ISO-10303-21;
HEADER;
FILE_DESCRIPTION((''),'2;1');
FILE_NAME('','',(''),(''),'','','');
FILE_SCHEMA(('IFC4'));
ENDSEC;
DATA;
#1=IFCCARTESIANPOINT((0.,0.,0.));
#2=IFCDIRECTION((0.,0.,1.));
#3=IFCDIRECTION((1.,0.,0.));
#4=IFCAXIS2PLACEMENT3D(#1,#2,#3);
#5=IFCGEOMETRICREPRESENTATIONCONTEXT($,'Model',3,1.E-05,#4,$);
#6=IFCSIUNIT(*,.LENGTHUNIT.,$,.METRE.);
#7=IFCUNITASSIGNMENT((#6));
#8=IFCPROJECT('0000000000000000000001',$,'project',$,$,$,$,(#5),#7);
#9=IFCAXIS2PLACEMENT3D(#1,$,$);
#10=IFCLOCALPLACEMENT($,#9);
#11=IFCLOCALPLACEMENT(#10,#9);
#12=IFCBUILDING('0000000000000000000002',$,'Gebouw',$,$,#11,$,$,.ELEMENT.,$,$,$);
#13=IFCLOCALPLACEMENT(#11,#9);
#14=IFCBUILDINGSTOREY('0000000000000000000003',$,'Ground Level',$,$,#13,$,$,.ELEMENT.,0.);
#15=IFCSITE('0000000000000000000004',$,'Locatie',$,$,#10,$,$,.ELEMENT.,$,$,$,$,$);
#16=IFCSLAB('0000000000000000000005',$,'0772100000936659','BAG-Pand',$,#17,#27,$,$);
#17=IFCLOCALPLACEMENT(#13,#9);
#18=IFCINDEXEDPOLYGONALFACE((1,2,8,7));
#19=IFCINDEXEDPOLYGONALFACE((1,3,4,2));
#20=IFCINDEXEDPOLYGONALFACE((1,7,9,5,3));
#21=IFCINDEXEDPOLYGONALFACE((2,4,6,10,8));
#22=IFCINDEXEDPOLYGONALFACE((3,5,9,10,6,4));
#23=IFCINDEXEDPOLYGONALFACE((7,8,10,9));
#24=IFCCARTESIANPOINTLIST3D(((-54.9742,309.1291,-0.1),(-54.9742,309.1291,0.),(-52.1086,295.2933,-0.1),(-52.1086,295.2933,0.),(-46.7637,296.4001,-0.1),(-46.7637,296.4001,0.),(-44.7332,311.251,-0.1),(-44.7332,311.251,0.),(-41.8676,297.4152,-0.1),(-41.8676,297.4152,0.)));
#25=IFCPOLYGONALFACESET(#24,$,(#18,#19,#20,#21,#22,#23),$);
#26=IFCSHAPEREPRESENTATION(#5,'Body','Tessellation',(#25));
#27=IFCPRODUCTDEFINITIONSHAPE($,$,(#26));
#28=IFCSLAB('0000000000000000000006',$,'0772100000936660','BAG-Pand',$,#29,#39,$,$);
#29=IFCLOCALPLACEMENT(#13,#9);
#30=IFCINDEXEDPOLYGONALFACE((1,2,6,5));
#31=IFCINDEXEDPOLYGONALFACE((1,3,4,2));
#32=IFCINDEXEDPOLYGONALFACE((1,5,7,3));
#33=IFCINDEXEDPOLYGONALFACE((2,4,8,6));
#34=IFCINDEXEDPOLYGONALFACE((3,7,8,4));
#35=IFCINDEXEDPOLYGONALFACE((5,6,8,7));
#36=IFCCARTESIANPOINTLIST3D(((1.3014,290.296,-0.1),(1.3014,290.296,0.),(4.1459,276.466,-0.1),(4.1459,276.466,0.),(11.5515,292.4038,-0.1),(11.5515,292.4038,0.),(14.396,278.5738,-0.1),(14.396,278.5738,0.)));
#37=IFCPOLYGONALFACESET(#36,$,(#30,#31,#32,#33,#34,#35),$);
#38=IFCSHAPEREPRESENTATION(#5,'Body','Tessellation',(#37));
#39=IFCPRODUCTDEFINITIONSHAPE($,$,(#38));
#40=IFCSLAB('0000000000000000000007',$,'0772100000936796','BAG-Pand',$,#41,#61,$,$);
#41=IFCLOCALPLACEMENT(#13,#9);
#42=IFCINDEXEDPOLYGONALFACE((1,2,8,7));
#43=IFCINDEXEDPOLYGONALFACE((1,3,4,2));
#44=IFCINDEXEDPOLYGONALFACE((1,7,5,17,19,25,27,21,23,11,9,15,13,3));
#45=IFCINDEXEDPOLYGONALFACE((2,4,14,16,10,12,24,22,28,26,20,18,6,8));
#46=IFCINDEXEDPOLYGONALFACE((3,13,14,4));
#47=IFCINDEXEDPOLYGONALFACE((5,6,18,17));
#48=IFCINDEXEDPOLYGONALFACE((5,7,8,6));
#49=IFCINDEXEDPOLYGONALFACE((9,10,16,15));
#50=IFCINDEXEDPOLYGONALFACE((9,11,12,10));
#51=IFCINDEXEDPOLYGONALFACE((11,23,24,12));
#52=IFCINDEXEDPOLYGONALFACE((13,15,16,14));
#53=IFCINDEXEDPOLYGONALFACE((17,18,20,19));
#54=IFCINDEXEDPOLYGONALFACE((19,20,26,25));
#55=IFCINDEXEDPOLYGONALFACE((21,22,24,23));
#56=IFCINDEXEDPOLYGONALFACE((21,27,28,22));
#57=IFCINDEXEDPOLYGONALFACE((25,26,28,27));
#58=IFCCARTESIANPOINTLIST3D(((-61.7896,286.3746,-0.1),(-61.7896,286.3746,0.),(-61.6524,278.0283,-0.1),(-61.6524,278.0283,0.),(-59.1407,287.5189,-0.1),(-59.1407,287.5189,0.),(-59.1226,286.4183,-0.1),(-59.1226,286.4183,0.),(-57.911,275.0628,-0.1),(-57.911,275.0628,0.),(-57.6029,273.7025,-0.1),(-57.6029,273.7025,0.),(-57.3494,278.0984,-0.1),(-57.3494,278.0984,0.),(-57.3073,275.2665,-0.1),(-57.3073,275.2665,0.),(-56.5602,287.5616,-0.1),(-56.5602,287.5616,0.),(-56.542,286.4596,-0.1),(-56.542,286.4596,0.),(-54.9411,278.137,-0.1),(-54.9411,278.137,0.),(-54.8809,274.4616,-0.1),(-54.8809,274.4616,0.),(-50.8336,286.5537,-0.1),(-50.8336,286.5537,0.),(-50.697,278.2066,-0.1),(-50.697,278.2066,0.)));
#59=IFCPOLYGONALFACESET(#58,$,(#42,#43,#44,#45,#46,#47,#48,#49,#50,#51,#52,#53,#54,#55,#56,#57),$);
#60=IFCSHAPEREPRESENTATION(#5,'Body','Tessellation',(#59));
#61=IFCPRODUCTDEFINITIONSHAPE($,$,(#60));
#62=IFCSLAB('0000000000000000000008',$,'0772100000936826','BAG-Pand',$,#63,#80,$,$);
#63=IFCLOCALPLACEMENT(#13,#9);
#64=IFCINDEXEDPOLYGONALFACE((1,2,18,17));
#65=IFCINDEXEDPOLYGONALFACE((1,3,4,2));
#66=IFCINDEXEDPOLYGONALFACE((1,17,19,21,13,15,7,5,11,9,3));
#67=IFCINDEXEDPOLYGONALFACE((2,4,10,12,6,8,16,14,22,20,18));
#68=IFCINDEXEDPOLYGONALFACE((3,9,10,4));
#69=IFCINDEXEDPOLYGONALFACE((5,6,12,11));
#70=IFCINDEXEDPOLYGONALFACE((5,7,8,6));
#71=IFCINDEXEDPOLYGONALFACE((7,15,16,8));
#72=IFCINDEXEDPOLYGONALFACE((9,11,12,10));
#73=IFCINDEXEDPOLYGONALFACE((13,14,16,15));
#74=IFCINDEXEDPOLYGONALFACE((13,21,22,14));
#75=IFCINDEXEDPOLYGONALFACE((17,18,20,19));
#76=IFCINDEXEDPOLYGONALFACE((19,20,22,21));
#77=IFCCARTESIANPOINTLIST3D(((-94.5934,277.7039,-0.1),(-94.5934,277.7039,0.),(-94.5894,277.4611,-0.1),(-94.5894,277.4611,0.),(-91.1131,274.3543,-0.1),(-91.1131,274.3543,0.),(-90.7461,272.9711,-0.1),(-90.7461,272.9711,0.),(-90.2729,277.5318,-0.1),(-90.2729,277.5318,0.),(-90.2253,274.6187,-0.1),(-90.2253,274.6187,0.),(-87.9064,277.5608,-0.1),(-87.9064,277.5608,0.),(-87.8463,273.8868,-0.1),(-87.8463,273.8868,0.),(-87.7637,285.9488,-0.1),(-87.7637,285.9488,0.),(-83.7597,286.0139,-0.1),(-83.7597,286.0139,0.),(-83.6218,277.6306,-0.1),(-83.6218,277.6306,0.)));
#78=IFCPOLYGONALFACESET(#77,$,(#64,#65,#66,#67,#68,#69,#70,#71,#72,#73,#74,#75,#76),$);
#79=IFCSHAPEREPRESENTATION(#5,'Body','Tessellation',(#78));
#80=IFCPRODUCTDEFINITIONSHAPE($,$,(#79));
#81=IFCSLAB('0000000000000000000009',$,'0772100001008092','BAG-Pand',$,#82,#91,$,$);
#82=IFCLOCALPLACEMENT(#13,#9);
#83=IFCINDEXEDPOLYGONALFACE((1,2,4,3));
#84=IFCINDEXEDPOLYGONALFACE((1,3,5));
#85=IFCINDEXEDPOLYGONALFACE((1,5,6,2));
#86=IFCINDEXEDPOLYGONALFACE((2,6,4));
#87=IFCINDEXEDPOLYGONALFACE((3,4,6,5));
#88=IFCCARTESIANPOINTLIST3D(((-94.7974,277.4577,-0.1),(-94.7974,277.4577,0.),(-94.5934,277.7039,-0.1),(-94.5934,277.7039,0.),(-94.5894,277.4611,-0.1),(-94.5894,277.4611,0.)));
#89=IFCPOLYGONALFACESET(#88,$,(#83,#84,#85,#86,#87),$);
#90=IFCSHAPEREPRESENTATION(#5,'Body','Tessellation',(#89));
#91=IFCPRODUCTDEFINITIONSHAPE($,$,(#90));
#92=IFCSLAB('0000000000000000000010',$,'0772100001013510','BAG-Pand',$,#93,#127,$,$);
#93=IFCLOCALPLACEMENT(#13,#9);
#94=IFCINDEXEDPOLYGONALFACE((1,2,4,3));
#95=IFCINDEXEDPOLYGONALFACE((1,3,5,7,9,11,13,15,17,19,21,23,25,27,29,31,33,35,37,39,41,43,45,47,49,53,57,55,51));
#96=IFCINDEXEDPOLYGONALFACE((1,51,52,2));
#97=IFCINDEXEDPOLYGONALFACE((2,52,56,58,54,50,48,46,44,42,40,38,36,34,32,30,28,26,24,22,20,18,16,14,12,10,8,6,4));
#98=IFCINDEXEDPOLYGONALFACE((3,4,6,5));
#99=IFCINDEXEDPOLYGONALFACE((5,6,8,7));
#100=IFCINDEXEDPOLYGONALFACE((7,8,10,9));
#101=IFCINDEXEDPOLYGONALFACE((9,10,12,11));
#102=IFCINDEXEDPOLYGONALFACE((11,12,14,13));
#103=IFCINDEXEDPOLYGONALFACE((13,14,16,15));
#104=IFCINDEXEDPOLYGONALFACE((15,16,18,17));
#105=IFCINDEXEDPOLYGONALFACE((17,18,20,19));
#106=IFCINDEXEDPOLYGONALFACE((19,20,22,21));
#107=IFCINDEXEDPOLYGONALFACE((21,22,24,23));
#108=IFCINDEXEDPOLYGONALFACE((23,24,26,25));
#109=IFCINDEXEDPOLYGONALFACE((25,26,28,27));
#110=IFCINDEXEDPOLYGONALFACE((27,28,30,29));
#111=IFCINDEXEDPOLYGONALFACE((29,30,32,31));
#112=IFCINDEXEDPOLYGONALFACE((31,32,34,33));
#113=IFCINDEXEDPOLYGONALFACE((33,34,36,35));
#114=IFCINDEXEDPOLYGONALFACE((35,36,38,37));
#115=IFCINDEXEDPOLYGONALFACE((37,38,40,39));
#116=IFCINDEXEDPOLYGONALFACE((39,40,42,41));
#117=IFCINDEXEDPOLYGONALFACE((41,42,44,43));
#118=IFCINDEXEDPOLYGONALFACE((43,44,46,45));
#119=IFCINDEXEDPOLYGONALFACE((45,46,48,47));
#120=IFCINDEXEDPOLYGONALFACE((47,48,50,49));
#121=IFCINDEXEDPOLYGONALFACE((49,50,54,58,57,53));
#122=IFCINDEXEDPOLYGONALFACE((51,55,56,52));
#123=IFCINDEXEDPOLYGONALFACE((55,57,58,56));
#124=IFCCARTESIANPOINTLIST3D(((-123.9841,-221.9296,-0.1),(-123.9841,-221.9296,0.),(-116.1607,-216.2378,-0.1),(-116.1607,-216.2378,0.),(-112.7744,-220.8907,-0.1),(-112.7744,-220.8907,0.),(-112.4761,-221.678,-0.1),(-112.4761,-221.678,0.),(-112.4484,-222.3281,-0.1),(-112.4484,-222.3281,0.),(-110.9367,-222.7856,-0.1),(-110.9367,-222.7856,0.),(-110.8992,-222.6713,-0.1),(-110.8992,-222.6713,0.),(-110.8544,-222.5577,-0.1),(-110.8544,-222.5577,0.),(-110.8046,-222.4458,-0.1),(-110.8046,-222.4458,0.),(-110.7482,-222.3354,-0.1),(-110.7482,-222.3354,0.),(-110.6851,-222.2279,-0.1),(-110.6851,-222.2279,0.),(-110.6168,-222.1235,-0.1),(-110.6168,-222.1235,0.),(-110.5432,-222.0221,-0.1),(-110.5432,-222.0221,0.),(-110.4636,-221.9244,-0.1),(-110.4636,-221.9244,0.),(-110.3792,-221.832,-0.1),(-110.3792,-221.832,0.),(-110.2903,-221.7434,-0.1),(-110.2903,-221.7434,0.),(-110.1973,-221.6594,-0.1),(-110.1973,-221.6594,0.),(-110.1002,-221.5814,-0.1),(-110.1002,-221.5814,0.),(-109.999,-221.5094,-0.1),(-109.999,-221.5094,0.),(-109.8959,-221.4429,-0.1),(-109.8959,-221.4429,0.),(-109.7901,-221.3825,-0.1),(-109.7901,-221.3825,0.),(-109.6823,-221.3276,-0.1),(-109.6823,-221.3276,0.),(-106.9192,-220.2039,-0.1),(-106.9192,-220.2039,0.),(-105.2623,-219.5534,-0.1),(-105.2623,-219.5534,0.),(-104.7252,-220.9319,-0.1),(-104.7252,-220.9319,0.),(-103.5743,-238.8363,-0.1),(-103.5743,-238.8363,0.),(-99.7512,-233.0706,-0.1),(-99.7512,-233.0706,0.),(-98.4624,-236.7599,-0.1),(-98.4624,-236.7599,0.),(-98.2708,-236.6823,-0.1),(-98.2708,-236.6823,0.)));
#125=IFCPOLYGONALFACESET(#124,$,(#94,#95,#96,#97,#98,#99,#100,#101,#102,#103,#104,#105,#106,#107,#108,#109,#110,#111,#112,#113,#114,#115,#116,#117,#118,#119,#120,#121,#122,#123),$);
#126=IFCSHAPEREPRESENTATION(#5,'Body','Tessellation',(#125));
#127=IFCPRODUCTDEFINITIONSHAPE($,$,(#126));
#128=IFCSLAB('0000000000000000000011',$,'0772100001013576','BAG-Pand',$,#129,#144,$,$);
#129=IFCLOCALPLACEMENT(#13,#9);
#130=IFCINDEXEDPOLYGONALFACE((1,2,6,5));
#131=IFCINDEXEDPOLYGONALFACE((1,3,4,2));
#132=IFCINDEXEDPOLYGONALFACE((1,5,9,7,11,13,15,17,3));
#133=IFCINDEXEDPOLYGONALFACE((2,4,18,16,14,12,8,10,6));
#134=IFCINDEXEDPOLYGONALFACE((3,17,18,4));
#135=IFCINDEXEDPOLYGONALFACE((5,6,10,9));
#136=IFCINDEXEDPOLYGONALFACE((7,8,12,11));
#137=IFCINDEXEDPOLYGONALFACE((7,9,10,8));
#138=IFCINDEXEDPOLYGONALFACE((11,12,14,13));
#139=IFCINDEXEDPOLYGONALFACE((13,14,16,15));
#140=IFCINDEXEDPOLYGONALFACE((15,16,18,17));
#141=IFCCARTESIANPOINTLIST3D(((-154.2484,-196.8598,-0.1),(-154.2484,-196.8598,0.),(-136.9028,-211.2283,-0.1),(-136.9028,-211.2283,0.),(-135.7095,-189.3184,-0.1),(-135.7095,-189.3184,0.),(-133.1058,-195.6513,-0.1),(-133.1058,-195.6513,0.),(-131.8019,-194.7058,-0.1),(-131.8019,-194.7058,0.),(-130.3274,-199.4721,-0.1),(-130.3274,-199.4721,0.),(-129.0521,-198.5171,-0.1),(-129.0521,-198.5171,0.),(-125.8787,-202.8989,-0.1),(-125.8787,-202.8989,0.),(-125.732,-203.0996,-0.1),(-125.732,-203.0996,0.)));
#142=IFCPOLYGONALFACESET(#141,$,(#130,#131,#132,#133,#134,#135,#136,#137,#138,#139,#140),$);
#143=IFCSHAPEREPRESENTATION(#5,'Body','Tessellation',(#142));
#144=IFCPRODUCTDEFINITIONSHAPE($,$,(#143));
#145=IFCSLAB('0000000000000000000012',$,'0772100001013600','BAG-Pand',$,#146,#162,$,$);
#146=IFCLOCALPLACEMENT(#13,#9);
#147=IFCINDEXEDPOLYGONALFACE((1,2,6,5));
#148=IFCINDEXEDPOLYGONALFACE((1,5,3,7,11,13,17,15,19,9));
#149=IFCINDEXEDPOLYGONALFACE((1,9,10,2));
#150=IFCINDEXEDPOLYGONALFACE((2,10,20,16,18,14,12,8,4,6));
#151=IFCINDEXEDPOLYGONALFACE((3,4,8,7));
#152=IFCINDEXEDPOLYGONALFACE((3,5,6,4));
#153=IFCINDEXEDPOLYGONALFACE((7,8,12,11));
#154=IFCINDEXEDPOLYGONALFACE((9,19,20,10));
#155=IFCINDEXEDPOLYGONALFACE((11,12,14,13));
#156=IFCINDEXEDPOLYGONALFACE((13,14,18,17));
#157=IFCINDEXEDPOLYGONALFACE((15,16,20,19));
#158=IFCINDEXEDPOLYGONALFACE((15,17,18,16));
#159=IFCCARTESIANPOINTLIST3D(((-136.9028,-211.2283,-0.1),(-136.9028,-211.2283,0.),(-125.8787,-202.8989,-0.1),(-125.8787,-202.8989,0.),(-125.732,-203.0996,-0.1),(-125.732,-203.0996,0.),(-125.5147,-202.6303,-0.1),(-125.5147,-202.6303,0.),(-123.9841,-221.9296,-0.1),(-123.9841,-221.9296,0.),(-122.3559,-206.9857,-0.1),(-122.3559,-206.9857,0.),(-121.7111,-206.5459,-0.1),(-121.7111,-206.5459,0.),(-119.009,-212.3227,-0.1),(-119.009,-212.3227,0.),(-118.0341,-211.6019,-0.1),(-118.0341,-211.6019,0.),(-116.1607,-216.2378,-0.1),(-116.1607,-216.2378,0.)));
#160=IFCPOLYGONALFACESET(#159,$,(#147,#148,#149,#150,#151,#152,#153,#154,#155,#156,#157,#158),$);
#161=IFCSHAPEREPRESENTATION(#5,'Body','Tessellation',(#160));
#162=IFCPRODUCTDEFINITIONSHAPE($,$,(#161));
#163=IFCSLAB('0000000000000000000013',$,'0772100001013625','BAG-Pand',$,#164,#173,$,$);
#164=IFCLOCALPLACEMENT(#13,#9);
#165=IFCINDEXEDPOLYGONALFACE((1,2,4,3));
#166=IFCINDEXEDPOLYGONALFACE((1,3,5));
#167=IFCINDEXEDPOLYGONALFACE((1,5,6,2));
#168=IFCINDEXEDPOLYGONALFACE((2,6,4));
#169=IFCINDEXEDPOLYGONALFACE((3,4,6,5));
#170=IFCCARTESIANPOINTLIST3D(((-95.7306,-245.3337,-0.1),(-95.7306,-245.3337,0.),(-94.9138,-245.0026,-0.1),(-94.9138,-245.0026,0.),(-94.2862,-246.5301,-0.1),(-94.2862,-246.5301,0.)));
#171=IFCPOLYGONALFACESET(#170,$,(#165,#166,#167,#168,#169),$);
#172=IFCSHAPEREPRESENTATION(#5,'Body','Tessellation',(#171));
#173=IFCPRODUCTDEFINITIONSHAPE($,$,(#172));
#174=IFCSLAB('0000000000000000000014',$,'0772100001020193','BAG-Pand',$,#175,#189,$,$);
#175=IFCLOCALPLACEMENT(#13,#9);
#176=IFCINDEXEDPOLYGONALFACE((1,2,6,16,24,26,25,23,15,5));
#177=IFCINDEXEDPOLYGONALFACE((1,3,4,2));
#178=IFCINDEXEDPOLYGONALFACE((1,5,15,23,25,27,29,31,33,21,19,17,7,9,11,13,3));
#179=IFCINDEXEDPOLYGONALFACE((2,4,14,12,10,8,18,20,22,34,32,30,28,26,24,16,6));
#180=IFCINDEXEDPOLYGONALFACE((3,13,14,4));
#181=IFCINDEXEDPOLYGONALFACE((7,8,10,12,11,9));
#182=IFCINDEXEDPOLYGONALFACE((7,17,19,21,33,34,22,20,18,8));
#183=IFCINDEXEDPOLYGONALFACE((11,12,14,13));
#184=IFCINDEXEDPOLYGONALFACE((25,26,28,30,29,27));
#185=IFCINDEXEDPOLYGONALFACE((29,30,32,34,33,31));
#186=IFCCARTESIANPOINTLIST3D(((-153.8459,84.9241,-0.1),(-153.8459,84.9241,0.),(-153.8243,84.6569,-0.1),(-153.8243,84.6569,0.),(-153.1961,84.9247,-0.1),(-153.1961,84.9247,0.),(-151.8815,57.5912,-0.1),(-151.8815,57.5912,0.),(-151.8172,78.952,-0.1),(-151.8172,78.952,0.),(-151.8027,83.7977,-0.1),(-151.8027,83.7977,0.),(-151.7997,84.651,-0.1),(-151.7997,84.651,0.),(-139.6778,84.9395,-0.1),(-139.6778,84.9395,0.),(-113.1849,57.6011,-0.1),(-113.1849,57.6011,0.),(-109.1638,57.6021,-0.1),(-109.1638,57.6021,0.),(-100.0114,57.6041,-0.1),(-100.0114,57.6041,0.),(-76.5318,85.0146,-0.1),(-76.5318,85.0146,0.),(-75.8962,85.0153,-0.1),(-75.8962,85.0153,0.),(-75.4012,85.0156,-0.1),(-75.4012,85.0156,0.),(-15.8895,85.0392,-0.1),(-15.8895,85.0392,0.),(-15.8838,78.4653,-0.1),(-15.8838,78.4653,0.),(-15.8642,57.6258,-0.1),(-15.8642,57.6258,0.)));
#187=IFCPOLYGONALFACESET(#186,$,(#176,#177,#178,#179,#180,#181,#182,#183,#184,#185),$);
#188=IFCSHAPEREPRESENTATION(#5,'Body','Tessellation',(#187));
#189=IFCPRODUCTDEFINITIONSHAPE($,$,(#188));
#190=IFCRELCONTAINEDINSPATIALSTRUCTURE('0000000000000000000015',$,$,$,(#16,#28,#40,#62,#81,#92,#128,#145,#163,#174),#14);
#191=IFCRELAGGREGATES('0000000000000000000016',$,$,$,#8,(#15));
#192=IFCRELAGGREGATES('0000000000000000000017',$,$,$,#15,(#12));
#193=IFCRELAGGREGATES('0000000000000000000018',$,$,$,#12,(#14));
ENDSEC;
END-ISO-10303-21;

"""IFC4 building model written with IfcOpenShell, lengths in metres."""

from ifc_helpers import new_model, si_unit, frame, origin, origin_with_axes, place, context, project, spatial, polyline, outline, extrude, element, save


model = new_model("IFC4")

# Units and contexts
model_context = context("Model", 3, precision=1e-05, world=origin_with_axes())
ifc_project = project(units=[si_unit("LENGTHUNIT", "METRE")], contexts=[model_context])

# Site, building, storey
site_placement = place(None, origin())
site = spatial("IfcSite", under=ifc_project, at=site_placement, Name="Locatie", CompositionType="ELEMENT")
building_placement = place(site_placement, origin())
building = spatial("IfcBuilding", under=site, at=building_placement, Name="Gebouw", CompositionType="ELEMENT")
storey_placement = place(building_placement, origin())
storey = spatial("IfcBuildingStorey", under=building, at=storey_placement, Name="Ground Level", CompositionType="ELEMENT", Elevation=0.0)

# Slabs
slab_1_placement = place(storey_placement, origin())
element("IfcSlab", 1, at=slab_1_placement, inside=storey, Name="0772100000936659", Description="BAG-Pand", context=model_context, shape_type="SweptSolid", body=[
    extrude(outline(polyline([(-44.7332, 311.251), (-41.8676, 297.4152), (-46.7637, 296.4001), (-52.1086, 295.2933), (-54.9742, 309.1291), (-44.7332, 311.251)])), frame((0.0, 0.0, -0.1), z_axis=(0.0, 0.0, 1.0), x_axis=(1.0, 0.0, 0.0)), (0.0, 0.0, 1.0), 0.1),
])
slab_2_placement = place(storey_placement, origin())
element("IfcSlab", 2, at=slab_2_placement, inside=storey, Name="0772100000936660", Description="BAG-Pand", context=model_context, shape_type="SweptSolid", body=[
    extrude(outline(polyline([(11.5515, 292.4038), (14.396, 278.5738), (4.1459, 276.466), (1.3014, 290.296), (11.5515, 292.4038)])), frame((0.0, 0.0, -0.1), z_axis=(0.0, 0.0, 1.0), x_axis=(1.0, 0.0, 0.0)), (0.0, 0.0, 1.0), 0.1),
])
slab_3_placement = place(storey_placement, origin())
element("IfcSlab", 3, at=slab_3_placement, inside=storey, Name="0772100000936796", Description="BAG-Pand", context=model_context, shape_type="SweptSolid", body=[
    extrude(outline(polyline([(-57.911, 275.0628), (-57.3073, 275.2665), (-57.3494, 278.0984), (-61.6524, 278.0283), (-61.7896, 286.3746), (-59.1226, 286.4183), (-59.1407, 287.5189), (-56.5602, 287.5616), (-56.542, 286.4596), (-50.8336, 286.5537), (-50.697, 278.2066), (-54.9411, 278.137), (-54.8809, 274.4616), (-57.6029, 273.7025), (-57.911, 275.0628)])), frame((0.0, 0.0, -0.1), z_axis=(0.0, 0.0, 1.0), x_axis=(1.0, 0.0, 0.0)), (0.0, 0.0, 1.0), 0.1),
])
slab_4_placement = place(storey_placement, origin())
element("IfcSlab", 4, at=slab_4_placement, inside=storey, Name="0772100000936826", Description="BAG-Pand", context=model_context, shape_type="SweptSolid", body=[
    extrude(outline(polyline([(-83.7597, 286.0139), (-83.6218, 277.6306), (-87.9064, 277.5608), (-87.8463, 273.8868), (-90.7461, 272.9711), (-91.1131, 274.3543), (-90.2253, 274.6187), (-90.2729, 277.5318), (-94.5894, 277.4611), (-94.5934, 277.7039), (-87.7637, 285.9488), (-83.7597, 286.0139)])), frame((0.0, 0.0, -0.1), z_axis=(0.0, 0.0, 1.0), x_axis=(1.0, 0.0, 0.0)), (0.0, 0.0, 1.0), 0.1),
])
slab_5_placement = place(storey_placement, origin())
element("IfcSlab", 5, at=slab_5_placement, inside=storey, Name="0772100001008092", Description="BAG-Pand", context=model_context, shape_type="SweptSolid", body=[
    extrude(outline(polyline([(-94.5894, 277.4611), (-94.7974, 277.4577), (-94.5934, 277.7039), (-94.5894, 277.4611)])), frame((0.0, 0.0, -0.1), z_axis=(0.0, 0.0, 1.0), x_axis=(1.0, 0.0, 0.0)), (0.0, 0.0, 1.0), 0.1),
])
slab_6_placement = place(storey_placement, origin())
element("IfcSlab", 6, at=slab_6_placement, inside=storey, Name="0772100001013510", Description="BAG-Pand", context=model_context, shape_type="SweptSolid", body=[
    extrude(outline(polyline([(-116.1607, -216.2378), (-112.7744, -220.8907), (-112.4761, -221.678), (-112.4484, -222.3281), (-110.9367, -222.7856), (-110.8992, -222.6713), (-110.8544, -222.5577), (-110.8046, -222.4458), (-110.7482, -222.3354), (-110.6851, -222.2279), (-110.6168, -222.1235), (-110.5432, -222.0221), (-110.4636, -221.9244), (-110.3792, -221.832), (-110.2903, -221.7434), (-110.1973, -221.6594), (-110.1002, -221.5814), (-109.999, -221.5094), (-109.8959, -221.4429), (-109.7901, -221.3825), (-109.6823, -221.3276), (-106.9192, -220.2039), (-105.2623, -219.5534), (-104.7252, -220.9319), (-99.7512, -233.0706), (-98.2708, -236.6823), (-98.4624, -236.7599), (-103.5743, -238.8363), (-123.9841, -221.9296), (-116.1607, -216.2378)])), frame((0.0, 0.0, -0.1), z_axis=(0.0, 0.0, 1.0), x_axis=(1.0, 0.0, 0.0)), (0.0, 0.0, 1.0), 0.1),
])
slab_7_placement = place(storey_placement, origin())
element("IfcSlab", 7, at=slab_7_placement, inside=storey, Name="0772100001013576", Description="BAG-Pand", context=model_context, shape_type="SweptSolid", body=[
    extrude(outline(polyline([(-135.7095, -189.3184), (-131.8019, -194.7058), (-133.1058, -195.6513), (-130.3274, -199.4721), (-129.0521, -198.5171), (-125.8787, -202.8989), (-125.732, -203.0996), (-136.9028, -211.2283), (-154.2484, -196.8598), (-135.7095, -189.3184)])), frame((0.0, 0.0, -0.1), z_axis=(0.0, 0.0, 1.0), x_axis=(1.0, 0.0, 0.0)), (0.0, 0.0, 1.0), 0.1),
])
slab_8_placement = place(storey_placement, origin())
element("IfcSlab", 8, at=slab_8_placement, inside=storey, Name="0772100001013600", Description="BAG-Pand", context=model_context, shape_type="SweptSolid", body=[
    extrude(outline(polyline([(-125.732, -203.0996), (-125.8787, -202.8989), (-125.5147, -202.6303), (-122.3559, -206.9857), (-121.7111, -206.5459), (-118.0341, -211.6019), (-119.009, -212.3227), (-116.1607, -216.2378), (-123.9841, -221.9296), (-136.9028, -211.2283), (-125.732, -203.0996)])), frame((0.0, 0.0, -0.1), z_axis=(0.0, 0.0, 1.0), x_axis=(1.0, 0.0, 0.0)), (0.0, 0.0, 1.0), 0.1),
])
slab_9_placement = place(storey_placement, origin())
element("IfcSlab", 9, at=slab_9_placement, inside=storey, Name="0772100001013625", Description="BAG-Pand", context=model_context, shape_type="SweptSolid", body=[
    extrude(outline(polyline([(-94.9138, -245.0026), (-94.2862, -246.5301), (-95.7306, -245.3337), (-94.9138, -245.0026)])), frame((0.0, 0.0, -0.1), z_axis=(0.0, 0.0, 1.0), x_axis=(1.0, 0.0, 0.0)), (0.0, 0.0, 1.0), 0.1),
])
slab_10_placement = place(storey_placement, origin())
element("IfcSlab", 10, at=slab_10_placement, inside=storey, Name="0772100001020193", Description="BAG-Pand", context=model_context, shape_type="SweptSolid", body=[
    extrude(outline(polyline([(-151.8172, 78.952), (-151.8027, 83.7977), (-151.7997, 84.651), (-153.8243, 84.6569), (-153.8459, 84.9241), (-153.1961, 84.9247), (-139.6778, 84.9395), (-76.5318, 85.0146), (-75.8962, 85.0153), (-75.4012, 85.0156), (-15.8895, 85.0392), (-15.8838, 78.4653), (-15.8642, 57.6258), (-100.0114, 57.6041), (-109.1638, 57.6021), (-113.1849, 57.6011), (-151.8815, 57.5912), (-151.8172, 78.952)])), frame((0.0, 0.0, -0.1), z_axis=(0.0, 0.0, 1.0), x_axis=(1.0, 0.0, 0.0)), (0.0, 0.0, 1.0), 0.1),
])

save(model, "model.ifc")
